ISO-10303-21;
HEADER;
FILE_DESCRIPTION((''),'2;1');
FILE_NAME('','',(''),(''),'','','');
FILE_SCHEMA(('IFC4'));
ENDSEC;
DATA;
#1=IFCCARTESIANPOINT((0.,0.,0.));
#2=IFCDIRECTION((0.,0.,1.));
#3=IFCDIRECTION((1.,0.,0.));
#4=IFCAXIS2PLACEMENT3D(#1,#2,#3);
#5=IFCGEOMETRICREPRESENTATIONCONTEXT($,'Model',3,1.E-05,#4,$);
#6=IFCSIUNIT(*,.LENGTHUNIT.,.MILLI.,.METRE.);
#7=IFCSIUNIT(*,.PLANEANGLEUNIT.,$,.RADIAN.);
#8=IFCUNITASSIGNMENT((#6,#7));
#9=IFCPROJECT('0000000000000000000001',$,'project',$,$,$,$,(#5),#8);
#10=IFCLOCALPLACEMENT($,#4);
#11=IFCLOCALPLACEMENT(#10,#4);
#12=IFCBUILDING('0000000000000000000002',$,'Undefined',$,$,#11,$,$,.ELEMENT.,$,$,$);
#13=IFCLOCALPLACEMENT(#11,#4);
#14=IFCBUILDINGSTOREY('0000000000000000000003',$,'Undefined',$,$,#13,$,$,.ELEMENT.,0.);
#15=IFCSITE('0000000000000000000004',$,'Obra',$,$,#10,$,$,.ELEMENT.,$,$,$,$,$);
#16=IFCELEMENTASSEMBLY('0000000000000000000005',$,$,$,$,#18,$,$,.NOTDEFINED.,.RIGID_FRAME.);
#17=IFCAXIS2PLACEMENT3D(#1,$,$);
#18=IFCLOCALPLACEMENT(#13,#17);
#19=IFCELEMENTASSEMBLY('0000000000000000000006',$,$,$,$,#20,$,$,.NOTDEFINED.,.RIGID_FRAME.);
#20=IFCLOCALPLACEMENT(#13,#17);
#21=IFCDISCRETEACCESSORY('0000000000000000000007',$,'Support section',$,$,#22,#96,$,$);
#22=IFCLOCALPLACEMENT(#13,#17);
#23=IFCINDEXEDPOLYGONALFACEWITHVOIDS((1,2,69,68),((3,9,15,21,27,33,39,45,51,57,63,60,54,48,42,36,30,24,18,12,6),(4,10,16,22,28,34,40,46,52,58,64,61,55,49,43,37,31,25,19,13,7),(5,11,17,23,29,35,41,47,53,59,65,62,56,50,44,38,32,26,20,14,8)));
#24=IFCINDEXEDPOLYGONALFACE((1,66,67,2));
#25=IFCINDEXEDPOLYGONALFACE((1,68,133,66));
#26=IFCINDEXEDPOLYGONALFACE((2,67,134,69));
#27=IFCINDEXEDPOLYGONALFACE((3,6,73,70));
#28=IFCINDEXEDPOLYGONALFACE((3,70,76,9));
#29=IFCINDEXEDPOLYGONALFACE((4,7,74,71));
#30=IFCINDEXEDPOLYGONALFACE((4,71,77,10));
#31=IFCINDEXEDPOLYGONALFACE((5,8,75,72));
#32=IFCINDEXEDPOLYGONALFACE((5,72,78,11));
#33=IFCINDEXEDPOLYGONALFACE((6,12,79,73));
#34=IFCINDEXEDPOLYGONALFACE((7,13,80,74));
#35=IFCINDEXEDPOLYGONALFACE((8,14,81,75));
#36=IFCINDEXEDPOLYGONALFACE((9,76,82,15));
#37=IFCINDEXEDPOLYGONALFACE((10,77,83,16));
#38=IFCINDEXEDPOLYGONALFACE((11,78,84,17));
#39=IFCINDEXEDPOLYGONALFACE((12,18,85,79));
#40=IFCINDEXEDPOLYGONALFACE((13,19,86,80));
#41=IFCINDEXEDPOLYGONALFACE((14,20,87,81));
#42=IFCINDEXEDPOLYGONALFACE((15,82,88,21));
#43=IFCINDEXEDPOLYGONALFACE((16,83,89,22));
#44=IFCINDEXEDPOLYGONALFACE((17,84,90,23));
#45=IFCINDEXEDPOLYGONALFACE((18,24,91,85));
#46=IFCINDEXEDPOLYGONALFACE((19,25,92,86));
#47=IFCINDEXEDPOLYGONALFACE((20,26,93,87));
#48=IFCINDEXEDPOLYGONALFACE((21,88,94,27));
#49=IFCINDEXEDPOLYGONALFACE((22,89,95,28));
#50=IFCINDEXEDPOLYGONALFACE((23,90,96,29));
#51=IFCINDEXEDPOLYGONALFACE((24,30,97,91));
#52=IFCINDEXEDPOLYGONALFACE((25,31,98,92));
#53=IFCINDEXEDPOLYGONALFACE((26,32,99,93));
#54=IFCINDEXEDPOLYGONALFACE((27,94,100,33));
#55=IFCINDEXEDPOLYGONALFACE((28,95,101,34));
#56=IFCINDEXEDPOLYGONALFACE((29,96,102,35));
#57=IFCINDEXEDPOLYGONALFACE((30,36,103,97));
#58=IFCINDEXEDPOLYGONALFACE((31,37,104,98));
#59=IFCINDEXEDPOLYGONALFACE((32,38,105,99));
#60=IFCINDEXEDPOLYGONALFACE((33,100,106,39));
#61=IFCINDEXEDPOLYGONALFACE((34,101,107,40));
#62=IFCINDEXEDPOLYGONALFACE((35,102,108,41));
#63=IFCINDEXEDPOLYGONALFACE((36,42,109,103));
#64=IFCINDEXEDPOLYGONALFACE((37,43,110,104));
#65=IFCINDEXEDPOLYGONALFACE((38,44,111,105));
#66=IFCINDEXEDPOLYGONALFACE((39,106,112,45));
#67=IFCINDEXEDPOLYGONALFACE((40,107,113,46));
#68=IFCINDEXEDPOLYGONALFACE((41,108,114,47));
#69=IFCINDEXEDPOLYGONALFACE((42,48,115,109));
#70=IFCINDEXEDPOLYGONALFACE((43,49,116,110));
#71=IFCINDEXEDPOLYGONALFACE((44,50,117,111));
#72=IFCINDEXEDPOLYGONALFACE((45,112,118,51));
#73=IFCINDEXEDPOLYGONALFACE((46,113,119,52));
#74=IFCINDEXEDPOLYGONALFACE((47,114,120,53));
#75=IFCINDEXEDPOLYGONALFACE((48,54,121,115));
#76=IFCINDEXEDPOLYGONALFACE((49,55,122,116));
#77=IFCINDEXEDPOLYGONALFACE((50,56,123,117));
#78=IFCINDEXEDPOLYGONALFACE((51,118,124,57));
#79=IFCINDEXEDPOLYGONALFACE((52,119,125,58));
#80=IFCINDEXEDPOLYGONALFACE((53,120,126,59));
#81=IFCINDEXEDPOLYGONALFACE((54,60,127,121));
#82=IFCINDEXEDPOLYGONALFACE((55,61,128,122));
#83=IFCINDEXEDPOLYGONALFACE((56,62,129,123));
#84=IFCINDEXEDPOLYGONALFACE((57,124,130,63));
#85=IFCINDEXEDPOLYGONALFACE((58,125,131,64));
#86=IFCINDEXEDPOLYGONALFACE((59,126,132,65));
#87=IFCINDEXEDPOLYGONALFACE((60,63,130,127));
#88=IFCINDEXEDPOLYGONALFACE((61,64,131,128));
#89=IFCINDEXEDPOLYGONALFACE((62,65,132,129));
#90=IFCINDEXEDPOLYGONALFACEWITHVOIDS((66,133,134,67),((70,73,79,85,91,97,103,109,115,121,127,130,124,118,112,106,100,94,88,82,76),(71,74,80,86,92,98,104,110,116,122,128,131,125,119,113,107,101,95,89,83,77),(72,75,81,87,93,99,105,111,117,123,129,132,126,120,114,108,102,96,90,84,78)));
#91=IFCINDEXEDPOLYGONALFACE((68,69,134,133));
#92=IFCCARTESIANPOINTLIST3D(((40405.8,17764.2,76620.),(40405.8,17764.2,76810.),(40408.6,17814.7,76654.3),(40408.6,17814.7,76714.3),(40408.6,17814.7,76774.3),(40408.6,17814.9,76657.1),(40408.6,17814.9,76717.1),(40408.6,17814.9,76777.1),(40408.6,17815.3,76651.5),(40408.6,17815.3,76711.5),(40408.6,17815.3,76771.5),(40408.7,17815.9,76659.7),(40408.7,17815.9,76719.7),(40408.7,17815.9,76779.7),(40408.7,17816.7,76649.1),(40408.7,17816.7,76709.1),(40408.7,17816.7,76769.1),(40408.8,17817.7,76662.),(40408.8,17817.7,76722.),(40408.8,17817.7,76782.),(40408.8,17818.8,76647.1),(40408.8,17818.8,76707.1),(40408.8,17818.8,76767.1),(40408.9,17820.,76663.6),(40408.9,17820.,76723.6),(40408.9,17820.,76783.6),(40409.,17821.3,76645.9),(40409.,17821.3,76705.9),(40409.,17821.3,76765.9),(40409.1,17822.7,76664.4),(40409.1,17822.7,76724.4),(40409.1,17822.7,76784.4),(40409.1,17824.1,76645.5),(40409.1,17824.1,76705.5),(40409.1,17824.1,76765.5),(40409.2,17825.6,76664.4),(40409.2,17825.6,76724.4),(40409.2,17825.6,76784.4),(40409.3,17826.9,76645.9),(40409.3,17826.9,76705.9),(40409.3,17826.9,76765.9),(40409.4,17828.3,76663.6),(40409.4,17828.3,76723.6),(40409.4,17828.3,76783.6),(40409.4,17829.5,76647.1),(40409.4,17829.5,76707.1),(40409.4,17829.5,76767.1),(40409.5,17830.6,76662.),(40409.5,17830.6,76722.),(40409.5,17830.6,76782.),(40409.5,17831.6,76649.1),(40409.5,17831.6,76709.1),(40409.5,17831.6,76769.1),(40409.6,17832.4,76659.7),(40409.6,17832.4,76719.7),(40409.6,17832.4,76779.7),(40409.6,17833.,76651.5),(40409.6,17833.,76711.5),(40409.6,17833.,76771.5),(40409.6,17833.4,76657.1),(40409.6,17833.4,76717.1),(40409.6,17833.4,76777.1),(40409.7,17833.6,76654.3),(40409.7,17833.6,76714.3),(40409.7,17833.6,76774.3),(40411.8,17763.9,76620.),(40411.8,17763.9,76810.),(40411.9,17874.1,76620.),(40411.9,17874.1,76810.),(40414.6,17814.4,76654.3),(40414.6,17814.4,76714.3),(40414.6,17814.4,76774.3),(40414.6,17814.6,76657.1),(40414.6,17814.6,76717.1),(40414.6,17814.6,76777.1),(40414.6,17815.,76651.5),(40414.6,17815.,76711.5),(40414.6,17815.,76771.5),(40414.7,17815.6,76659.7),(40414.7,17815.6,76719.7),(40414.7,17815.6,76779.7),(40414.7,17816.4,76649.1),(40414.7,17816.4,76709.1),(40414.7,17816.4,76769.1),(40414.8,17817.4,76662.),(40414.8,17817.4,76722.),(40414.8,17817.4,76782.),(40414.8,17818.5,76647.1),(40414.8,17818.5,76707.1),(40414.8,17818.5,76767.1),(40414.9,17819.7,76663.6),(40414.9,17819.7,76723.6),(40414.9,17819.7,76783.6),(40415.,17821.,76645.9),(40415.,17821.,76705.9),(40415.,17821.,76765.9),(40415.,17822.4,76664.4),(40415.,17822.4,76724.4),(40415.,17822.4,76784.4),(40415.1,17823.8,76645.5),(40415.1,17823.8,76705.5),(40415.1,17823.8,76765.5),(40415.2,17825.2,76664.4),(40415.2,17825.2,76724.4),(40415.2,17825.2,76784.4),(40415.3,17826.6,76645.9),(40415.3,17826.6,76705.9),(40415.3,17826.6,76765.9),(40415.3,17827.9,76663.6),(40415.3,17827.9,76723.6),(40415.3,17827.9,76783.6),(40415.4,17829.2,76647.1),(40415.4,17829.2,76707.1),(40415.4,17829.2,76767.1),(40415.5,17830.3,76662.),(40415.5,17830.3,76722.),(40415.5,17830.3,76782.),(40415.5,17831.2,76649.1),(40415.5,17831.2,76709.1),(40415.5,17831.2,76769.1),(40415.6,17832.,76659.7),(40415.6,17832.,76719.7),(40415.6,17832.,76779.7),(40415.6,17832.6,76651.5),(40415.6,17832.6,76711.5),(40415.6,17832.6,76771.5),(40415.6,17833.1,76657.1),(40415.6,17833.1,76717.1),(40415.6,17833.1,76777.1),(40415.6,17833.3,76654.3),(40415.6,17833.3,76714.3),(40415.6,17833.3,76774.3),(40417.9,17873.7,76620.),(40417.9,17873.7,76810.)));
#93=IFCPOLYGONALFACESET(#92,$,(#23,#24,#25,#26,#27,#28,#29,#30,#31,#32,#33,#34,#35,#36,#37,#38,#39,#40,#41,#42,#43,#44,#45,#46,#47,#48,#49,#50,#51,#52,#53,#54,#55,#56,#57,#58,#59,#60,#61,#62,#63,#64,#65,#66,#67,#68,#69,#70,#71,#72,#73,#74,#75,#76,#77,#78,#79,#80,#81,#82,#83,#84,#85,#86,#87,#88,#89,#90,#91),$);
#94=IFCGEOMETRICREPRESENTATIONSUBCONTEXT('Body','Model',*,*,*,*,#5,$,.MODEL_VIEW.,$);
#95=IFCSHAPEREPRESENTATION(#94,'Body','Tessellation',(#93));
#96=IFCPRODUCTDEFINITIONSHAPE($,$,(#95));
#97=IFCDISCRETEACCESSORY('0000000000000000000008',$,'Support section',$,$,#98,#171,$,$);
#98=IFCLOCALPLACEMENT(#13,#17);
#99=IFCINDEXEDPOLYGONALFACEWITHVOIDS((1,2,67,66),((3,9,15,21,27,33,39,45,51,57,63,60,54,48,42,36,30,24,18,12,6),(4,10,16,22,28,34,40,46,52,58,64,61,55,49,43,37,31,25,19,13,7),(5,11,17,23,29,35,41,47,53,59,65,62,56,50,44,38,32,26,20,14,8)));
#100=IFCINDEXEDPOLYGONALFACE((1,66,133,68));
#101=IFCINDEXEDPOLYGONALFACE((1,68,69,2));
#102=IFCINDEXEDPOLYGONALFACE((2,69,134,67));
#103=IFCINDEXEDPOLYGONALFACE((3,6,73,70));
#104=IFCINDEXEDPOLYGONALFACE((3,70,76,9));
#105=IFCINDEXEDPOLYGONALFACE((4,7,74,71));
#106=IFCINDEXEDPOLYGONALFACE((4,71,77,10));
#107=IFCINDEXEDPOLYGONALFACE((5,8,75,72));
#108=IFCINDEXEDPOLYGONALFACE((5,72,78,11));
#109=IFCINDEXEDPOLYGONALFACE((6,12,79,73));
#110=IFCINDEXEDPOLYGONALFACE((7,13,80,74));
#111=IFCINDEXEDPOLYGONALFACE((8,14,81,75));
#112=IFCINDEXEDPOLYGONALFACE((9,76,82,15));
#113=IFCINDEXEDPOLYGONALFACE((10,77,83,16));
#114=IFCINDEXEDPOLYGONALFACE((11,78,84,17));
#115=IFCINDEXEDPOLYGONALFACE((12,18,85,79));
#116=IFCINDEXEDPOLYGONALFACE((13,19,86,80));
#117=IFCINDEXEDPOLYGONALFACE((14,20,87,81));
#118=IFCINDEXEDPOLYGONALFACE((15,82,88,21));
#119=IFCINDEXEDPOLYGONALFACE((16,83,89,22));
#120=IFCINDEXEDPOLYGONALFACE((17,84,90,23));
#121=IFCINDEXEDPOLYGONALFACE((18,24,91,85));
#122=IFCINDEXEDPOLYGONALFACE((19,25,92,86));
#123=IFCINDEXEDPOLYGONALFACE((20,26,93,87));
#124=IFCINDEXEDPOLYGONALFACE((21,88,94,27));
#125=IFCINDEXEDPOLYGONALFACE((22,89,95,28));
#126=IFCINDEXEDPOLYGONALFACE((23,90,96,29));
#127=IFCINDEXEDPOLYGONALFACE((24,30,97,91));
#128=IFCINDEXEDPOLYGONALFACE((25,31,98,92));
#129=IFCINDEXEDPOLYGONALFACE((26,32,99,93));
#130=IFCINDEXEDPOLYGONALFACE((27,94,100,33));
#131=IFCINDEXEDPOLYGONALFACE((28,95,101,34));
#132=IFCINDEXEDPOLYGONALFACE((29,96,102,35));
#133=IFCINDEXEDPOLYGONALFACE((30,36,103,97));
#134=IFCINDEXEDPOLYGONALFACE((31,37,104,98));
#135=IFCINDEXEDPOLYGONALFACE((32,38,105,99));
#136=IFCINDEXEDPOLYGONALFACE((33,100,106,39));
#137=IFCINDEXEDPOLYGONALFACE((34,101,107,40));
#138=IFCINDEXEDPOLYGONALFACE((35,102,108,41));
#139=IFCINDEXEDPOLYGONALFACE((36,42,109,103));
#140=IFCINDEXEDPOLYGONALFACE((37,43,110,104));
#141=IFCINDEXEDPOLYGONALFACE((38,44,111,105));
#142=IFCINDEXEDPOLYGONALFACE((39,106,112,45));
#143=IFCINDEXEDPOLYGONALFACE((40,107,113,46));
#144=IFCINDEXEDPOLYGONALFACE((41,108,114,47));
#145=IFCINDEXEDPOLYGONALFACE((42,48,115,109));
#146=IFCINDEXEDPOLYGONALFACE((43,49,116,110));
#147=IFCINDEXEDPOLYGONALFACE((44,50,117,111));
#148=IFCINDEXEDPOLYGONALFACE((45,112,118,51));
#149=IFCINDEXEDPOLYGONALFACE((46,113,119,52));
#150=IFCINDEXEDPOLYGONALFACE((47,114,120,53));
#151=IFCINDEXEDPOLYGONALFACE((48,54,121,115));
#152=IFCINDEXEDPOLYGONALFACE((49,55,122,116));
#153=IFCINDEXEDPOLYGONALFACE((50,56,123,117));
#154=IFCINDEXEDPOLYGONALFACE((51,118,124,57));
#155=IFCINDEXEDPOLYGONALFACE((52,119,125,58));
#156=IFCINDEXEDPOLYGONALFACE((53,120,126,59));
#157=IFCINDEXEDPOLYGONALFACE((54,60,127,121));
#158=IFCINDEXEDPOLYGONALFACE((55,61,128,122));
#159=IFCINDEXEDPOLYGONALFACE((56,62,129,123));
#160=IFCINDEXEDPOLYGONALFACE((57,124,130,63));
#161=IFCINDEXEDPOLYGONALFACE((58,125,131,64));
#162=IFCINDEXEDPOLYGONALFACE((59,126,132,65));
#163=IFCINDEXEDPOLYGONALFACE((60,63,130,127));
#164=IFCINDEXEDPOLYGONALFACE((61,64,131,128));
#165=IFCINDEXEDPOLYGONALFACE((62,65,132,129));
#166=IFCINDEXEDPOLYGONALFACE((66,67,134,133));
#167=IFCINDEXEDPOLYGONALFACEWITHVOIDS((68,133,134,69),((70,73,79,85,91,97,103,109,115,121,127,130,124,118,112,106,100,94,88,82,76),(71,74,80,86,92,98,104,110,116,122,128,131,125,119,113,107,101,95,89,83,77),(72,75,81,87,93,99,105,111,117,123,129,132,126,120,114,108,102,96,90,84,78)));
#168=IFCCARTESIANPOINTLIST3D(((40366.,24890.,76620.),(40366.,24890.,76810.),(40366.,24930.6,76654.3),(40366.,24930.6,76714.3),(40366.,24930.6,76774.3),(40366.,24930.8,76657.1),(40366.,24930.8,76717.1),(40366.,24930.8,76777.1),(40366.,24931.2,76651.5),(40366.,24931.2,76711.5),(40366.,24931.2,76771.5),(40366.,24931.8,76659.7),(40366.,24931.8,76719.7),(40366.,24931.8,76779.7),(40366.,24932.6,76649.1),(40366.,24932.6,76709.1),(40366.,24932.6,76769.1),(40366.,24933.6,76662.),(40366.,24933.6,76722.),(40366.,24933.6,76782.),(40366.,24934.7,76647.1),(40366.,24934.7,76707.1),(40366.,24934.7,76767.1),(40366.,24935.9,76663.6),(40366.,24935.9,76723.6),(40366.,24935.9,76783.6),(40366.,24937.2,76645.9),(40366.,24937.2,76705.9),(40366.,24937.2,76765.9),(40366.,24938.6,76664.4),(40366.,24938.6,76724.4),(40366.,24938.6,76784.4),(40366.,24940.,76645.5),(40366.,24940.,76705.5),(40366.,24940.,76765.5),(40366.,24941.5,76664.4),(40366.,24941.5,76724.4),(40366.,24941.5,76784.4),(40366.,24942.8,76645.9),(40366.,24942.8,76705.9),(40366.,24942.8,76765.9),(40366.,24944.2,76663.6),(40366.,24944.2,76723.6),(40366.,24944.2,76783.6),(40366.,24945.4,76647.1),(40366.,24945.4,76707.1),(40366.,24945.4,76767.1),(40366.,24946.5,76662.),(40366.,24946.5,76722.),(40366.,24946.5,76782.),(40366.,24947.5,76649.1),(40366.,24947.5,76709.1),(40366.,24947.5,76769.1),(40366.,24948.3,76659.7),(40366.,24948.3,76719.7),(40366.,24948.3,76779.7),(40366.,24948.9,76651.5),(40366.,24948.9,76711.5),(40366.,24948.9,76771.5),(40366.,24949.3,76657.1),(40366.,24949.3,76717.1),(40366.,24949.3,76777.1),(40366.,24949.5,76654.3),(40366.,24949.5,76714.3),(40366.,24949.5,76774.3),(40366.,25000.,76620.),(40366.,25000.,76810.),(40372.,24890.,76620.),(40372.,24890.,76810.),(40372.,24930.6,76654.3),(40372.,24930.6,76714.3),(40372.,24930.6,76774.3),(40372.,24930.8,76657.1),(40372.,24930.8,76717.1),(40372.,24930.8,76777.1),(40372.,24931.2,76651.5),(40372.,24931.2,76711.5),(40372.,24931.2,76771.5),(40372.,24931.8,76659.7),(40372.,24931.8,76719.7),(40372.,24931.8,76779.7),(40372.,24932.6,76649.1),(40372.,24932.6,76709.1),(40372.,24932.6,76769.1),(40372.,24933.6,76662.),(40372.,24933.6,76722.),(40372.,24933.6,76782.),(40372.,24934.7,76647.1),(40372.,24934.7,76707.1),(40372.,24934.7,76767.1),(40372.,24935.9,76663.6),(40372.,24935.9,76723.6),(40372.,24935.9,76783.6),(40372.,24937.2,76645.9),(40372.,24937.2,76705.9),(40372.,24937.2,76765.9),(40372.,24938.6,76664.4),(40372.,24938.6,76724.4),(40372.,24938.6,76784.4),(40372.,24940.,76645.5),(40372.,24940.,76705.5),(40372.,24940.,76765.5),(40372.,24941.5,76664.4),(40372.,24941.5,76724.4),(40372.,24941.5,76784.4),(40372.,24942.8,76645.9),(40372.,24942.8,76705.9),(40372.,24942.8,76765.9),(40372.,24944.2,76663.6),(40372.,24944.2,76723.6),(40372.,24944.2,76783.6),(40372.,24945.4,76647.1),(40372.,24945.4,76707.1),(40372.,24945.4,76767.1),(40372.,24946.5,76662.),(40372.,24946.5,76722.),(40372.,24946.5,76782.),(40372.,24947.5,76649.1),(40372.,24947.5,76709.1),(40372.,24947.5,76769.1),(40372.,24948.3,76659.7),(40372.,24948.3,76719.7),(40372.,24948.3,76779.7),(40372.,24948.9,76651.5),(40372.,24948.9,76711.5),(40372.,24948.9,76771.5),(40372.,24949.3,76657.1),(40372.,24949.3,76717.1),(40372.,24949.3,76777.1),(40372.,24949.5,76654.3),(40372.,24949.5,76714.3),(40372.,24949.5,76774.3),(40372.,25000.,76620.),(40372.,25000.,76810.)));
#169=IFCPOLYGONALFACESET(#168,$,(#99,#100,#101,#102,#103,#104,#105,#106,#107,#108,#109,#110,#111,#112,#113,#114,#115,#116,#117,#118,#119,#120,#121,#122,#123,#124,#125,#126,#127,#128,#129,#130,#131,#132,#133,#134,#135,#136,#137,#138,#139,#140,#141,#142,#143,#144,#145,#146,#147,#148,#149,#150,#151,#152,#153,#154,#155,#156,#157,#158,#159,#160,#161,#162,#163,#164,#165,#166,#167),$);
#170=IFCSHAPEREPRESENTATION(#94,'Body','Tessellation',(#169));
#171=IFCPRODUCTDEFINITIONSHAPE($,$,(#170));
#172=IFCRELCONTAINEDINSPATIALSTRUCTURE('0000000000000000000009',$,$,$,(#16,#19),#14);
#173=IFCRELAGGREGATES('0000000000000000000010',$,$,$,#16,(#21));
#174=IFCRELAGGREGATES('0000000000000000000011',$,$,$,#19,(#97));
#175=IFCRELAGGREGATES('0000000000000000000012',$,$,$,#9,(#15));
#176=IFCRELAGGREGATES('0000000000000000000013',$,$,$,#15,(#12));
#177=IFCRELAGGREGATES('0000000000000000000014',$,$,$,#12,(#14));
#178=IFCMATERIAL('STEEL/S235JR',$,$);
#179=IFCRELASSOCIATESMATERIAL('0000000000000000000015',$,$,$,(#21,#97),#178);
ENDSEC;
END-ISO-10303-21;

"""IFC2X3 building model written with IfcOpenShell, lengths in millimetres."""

from ifc_helpers import new_model, si_unit, frame, origin_with_axes, origin_2d_with_axis, place, context, subcontext, project, spatial, rectangle, circle, extrude, source, transform, mapped, material, element, aggregate, save


model = new_model("IFC2X3")

# Units and contexts
model_context = context("Model", 3, precision=1e-05, world=origin_with_axes())
body_context = subcontext(model_context, "Body", "Model", "MODEL_VIEW")
ifc_project = project(units=[si_unit("LENGTHUNIT", "METRE", prefix="MILLI"), si_unit("PLANEANGLEUNIT", "RADIAN")], contexts=[model_context])

# Site, building, storey
site_placement = place(None, origin_with_axes())
site = spatial("IfcSite", under=ifc_project, at=site_placement, Name="Obra", CompositionType="ELEMENT")
building_placement = place(site_placement, origin_with_axes())
building = spatial("IfcBuilding", under=site, at=building_placement, Name="Undefined", CompositionType="ELEMENT")
storey_placement = place(building_placement, origin_with_axes())
storey = spatial("IfcBuildingStorey", under=building, at=storey_placement, Name="Undefined", CompositionType="ELEMENT", Elevation=0.0)

# Element assemblies
ifc_material_1 = material(Name="STEEL/S235JR")
assembly_1_placement = place(storey_placement, origin_with_axes())
assembly_1 = element("IfcElementAssembly", 1, at=assembly_1_placement, inside=storey, AssemblyPlace="NOTDEFINED", PredefinedType="RIGID_FRAME")
assembly_2_placement = place(storey_placement, origin_with_axes())
assembly_2 = element("IfcElementAssembly", 2, at=assembly_2_placement, inside=storey, AssemblyPlace="NOTDEFINED", PredefinedType="RIGID_FRAME")

# Discrete accessories, openings
shared_shape = source(origin_with_axes(), body_context, "Body", "SweptSolid", [
    extrude(circle(Radius=9.5, at=origin_2d_with_axis()), frame((0.0, -9.2, 0.0), z_axis=(0.0, 1.0, 0.0), x_axis=(1.0, 0.0, 0.0)), (0.0, 0.0, 1.0), 6.2),
])
discrete_accessory_1_placement = place(assembly_1_placement, frame((40411.9, 17819.0, 76620.0), z_axis=(0.0, 0.0, 1.0), x_axis=(-0.055268, -0.998472, 0.0)))
discrete_accessory_1 = element("IfcDiscreteAccessory", 3, at=discrete_accessory_1_placement, material=ifc_material_1, Name="Support section", context=body_context, shape_type="SweptSolid", body=[
    extrude(rectangle(XDim=6.0, YDim=110.0, at=origin_2d_with_axis()), frame((0.0, 0.0, 190.0), z_axis=(0.0, 0.0, -1.0), x_axis=(0.0, 1.0, 0.0)), (0.0, 0.0, 1.0), 190.0),
])
opening_1_placement = place(assembly_1_placement, frame((40403.3, 17774.4, 76835.0), z_axis=(0.055268, 0.998472, 0.0), x_axis=(0.0, 0.0, -1.0)))
element("IfcOpeningElement", 4, at=opening_1_placement, cuts=discrete_accessory_1, ObjectType="Opening", context=body_context, shape_type="MappedRepresentation", body=[
    mapped(shared_shape, transform((60.0, 0.0, 50.0))),
    mapped(shared_shape, transform((120.0, 0.0, 50.0))),
    mapped(shared_shape, transform((180.0, 0.0, 50.0))),
])
aggregate(assembly_1, [discrete_accessory_1])
discrete_accessory_2_placement = place(assembly_2_placement, frame((40369.0, 24945.0, 76620.0), z_axis=(0.0, 0.0, 1.0), x_axis=(-0.000002, 1.0, 0.0)))
discrete_accessory_2 = element("IfcDiscreteAccessory", 5, at=discrete_accessory_2_placement, material=ifc_material_1, Name="Support section", context=body_context, shape_type="SweptSolid", body=[
    extrude(rectangle(XDim=6.0, YDim=110.0, at=origin_2d_with_axis()), frame((0.0, 0.0, 190.0), z_axis=(0.0, 0.0, -1.0), x_axis=(0.0, 1.0, 0.0)), (0.0, 0.0, 1.0), 190.0),
])
opening_2_placement = place(assembly_2_placement, frame((40375.1, 24990.0, 76835.0), z_axis=(0.000002, -1.0, 0.0), x_axis=(0.0, 0.0, -1.0)))
element("IfcOpeningElement", 6, at=opening_2_placement, cuts=discrete_accessory_2, ObjectType="Opening", context=body_context, shape_type="MappedRepresentation", body=[
    mapped(shared_shape, transform((60.0, 0.0, 50.0))),
    mapped(shared_shape, transform((120.0, 0.0, 50.0))),
    mapped(shared_shape, transform((180.0, 0.0, 50.0))),
])
aggregate(assembly_2, [discrete_accessory_2])

save(model, "model.ifc")
